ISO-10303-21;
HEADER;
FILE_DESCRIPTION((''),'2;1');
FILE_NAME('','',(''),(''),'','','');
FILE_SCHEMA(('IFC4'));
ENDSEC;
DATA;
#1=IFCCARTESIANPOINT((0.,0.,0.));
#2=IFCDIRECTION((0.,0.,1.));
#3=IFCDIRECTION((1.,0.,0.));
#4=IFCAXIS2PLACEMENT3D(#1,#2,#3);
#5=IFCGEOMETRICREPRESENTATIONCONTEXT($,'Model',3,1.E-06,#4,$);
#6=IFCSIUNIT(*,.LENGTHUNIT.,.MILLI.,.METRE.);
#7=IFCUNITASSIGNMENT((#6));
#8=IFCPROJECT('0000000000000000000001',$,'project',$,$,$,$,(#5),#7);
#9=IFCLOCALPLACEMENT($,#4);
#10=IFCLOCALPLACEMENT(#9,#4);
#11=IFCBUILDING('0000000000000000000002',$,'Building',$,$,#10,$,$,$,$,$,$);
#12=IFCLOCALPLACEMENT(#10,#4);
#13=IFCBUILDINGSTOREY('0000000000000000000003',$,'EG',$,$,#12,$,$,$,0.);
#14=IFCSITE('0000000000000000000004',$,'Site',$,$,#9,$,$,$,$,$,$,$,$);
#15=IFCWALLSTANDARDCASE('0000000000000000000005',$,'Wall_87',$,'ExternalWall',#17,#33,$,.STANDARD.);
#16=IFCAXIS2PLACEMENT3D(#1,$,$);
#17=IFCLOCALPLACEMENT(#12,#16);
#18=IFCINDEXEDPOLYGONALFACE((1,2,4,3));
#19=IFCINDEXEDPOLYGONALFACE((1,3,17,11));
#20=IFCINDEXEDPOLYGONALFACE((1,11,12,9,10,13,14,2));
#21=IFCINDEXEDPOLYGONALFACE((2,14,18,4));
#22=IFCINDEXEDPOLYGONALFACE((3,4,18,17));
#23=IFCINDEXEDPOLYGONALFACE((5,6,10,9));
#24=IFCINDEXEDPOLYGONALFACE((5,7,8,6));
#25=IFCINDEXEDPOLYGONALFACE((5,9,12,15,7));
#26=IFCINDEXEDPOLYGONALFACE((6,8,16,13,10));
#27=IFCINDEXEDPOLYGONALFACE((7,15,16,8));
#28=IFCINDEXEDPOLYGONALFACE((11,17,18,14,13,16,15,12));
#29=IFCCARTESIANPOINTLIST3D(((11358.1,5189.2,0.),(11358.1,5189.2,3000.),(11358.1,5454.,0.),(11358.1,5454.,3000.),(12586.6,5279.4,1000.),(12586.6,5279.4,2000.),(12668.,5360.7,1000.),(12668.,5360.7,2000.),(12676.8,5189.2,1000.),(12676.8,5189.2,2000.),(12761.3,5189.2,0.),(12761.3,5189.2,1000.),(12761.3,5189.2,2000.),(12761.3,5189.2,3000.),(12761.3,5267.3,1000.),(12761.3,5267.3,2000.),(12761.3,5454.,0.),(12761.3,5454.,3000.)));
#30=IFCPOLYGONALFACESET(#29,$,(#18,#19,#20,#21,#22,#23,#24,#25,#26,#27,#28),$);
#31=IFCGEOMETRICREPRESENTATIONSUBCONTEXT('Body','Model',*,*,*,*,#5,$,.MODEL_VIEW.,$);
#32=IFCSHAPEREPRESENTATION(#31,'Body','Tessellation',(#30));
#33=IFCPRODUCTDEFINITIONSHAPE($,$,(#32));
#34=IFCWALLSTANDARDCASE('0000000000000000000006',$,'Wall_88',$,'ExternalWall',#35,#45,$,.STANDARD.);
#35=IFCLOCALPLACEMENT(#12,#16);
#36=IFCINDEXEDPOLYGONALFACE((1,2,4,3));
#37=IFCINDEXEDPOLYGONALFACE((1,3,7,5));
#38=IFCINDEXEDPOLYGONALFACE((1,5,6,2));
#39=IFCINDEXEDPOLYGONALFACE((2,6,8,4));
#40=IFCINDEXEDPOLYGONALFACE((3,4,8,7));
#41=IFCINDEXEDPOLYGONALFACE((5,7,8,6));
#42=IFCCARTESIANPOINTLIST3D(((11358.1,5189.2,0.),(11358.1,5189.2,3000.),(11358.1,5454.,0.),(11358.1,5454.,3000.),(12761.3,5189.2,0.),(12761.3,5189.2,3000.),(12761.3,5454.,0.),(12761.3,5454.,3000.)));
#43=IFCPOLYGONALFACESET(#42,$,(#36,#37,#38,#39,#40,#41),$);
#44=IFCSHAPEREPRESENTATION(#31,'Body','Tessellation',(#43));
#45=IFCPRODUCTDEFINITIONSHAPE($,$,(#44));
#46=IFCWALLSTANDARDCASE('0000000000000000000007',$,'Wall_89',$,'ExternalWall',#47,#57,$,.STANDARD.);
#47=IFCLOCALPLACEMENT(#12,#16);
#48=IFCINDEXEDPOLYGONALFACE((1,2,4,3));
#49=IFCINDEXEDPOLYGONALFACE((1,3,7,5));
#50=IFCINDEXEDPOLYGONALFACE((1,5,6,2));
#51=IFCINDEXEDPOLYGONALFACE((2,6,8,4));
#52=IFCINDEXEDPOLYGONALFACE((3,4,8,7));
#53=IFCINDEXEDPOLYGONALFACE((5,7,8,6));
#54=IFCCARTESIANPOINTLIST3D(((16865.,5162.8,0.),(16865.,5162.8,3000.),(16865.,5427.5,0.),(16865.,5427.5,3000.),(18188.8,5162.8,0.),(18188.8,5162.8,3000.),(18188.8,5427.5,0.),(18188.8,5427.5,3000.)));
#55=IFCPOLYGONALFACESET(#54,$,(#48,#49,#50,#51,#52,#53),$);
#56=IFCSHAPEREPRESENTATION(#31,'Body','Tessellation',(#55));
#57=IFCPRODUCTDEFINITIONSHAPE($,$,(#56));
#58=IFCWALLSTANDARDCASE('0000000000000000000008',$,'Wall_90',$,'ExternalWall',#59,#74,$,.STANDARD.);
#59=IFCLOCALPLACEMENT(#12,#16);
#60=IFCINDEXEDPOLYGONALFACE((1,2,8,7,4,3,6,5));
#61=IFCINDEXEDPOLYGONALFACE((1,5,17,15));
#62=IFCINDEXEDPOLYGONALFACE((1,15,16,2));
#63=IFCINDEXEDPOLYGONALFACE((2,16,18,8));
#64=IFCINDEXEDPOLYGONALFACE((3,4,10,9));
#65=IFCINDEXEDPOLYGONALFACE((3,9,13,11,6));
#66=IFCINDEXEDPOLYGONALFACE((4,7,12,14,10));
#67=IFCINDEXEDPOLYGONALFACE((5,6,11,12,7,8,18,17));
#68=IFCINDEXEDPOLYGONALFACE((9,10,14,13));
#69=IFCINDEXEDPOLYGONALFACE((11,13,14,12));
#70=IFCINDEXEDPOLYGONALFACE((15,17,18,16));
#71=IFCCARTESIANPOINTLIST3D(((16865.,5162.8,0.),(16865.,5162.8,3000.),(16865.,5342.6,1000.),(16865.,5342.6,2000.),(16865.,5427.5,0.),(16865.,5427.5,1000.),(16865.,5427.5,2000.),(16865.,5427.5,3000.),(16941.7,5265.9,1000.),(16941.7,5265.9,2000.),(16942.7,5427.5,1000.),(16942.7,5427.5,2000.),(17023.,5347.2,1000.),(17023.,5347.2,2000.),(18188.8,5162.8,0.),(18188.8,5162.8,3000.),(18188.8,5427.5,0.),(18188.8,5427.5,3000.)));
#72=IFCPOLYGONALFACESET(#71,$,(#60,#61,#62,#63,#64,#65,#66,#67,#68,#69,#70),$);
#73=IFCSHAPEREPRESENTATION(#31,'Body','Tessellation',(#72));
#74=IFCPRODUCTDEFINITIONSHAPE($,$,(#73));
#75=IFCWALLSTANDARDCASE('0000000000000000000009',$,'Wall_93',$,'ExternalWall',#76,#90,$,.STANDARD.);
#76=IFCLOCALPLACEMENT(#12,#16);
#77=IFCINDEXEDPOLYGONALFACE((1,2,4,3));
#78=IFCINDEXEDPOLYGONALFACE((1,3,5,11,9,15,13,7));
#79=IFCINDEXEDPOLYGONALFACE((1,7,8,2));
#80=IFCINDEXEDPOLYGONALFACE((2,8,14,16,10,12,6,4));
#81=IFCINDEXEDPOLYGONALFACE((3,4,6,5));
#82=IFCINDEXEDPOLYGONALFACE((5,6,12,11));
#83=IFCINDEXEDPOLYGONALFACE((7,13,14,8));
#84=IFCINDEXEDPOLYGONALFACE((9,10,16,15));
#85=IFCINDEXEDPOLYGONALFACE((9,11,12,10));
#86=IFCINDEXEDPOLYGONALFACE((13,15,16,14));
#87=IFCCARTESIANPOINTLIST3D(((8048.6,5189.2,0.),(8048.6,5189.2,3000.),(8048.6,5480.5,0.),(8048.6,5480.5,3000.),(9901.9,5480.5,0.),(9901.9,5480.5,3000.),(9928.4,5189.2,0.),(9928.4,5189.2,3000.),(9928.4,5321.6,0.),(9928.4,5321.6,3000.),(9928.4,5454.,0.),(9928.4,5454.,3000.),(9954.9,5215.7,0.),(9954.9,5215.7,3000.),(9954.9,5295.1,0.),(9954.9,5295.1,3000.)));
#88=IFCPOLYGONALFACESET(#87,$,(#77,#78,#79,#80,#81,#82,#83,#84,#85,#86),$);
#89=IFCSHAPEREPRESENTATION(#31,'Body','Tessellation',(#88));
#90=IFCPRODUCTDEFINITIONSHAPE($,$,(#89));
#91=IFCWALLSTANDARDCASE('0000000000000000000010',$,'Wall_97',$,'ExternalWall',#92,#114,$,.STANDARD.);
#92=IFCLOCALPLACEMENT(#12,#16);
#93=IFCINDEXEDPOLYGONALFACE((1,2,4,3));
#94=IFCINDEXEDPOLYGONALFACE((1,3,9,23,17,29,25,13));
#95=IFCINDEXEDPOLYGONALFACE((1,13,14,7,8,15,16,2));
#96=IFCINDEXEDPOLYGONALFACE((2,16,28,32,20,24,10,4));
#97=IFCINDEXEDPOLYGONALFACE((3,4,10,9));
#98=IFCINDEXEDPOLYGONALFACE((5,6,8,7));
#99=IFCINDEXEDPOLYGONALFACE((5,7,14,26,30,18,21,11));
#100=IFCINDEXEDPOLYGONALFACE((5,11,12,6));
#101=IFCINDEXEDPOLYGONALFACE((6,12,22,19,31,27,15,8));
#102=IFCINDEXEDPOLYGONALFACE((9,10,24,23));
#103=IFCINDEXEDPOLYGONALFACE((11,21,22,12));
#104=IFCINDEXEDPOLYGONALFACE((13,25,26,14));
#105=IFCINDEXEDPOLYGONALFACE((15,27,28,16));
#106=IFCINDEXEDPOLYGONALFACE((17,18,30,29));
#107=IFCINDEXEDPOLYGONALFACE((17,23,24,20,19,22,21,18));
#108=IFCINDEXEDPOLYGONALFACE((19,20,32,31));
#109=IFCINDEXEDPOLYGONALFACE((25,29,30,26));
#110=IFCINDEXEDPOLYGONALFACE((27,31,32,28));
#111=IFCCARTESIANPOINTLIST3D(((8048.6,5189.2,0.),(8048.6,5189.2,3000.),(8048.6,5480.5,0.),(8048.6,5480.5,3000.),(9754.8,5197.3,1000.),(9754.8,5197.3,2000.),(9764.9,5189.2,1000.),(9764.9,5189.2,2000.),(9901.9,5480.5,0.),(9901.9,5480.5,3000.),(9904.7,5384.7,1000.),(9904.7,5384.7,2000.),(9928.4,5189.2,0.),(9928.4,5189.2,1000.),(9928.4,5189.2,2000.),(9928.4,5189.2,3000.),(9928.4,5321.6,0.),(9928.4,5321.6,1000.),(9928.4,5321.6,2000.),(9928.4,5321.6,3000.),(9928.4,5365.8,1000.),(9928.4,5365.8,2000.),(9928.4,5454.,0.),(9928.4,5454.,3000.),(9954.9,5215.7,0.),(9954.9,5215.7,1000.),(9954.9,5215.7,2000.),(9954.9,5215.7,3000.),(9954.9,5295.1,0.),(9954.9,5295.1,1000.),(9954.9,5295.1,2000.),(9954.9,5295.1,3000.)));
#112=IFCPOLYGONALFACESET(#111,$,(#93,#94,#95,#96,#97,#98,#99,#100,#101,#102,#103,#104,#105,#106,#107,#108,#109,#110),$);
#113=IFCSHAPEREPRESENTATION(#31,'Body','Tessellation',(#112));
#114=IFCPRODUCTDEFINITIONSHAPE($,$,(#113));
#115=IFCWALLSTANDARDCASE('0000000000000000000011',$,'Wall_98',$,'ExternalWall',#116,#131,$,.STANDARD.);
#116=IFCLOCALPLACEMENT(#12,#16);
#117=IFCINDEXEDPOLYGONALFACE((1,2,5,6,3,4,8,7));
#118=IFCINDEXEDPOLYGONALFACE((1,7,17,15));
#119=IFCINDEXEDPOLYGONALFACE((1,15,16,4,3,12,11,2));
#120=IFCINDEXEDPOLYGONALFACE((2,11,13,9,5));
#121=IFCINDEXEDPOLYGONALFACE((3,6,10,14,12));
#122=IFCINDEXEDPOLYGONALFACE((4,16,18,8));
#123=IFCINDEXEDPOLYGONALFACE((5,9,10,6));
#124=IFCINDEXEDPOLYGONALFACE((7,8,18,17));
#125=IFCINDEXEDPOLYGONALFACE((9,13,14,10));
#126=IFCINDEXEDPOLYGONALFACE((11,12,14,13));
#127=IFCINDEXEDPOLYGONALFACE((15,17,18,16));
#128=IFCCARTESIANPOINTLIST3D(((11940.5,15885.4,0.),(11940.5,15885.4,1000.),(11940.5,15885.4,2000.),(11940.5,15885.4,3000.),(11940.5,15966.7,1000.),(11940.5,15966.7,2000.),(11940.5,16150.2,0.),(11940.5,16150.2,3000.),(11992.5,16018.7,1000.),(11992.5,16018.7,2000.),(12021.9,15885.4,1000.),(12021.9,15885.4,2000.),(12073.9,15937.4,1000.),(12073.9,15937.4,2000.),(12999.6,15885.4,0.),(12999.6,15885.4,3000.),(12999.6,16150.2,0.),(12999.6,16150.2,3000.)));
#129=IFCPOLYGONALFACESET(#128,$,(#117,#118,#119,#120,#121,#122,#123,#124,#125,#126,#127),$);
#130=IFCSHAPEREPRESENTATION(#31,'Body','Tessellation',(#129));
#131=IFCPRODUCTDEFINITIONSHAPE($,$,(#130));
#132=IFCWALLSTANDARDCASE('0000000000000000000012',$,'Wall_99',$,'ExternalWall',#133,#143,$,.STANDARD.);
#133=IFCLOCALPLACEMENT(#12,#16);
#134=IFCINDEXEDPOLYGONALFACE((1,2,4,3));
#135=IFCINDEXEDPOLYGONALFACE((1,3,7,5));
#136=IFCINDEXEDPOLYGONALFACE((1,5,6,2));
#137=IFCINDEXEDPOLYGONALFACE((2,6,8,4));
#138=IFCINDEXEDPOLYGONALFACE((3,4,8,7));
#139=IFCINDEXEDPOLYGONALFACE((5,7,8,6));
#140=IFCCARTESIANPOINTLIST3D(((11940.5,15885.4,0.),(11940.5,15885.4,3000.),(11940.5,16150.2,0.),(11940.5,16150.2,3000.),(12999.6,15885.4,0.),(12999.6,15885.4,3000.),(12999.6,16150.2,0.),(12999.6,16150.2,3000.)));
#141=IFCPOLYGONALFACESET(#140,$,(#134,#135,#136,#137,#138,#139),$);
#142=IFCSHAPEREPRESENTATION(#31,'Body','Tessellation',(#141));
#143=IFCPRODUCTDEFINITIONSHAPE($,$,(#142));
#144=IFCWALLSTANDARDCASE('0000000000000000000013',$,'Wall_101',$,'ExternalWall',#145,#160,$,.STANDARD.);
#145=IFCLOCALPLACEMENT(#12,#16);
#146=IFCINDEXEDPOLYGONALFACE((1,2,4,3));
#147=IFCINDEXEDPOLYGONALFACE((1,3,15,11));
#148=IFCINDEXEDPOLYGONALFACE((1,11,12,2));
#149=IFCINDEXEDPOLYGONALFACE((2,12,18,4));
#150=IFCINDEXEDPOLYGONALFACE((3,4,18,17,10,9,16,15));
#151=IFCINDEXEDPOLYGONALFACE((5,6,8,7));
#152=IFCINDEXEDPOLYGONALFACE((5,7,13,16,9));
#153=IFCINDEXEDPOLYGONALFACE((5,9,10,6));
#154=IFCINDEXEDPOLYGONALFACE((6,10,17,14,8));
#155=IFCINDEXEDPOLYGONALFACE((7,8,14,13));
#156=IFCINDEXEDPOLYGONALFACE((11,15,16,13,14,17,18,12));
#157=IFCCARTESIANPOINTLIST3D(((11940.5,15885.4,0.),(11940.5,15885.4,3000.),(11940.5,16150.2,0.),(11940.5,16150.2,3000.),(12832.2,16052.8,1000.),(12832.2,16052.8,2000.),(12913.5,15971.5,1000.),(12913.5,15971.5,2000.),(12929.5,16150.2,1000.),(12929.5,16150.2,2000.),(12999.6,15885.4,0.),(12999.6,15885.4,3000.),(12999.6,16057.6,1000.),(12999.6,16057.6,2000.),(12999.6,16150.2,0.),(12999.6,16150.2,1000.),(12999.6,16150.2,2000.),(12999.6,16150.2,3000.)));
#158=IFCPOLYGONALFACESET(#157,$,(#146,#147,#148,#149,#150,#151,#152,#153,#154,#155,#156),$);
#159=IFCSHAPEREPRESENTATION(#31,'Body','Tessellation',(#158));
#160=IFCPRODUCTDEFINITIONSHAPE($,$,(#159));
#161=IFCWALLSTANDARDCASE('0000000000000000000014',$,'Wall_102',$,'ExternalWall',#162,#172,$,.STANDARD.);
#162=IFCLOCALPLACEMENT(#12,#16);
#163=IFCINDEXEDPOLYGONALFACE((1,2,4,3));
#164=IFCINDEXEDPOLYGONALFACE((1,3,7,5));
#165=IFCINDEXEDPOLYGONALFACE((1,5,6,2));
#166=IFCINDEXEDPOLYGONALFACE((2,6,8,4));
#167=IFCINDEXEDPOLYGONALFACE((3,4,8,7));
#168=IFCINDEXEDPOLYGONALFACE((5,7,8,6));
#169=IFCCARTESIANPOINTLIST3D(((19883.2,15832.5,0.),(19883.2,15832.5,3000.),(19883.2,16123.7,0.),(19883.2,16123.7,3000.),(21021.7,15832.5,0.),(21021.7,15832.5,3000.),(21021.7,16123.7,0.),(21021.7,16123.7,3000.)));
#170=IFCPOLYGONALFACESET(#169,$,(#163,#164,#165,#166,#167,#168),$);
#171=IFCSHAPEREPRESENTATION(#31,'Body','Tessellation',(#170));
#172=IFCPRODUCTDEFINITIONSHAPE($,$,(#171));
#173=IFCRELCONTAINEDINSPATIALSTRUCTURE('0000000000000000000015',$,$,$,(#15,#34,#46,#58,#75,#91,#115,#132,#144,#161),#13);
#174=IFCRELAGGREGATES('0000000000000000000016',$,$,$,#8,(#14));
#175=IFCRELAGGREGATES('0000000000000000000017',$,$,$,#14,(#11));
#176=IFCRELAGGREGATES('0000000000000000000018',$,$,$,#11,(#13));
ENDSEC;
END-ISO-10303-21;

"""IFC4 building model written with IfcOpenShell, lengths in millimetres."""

from ifc_helpers import new_model, si_unit, frame, origin_with_axes, place, context, subcontext, project, spatial, polyline, rectangle, outline, extrude, element, save


model = new_model("IFC4")

# Units and contexts
model_context = context("Model", 3, precision=1e-06, world=origin_with_axes())
body_context = subcontext(model_context, "Body", "Model", "MODEL_VIEW")
ifc_project = project(units=[si_unit("LENGTHUNIT", "METRE", prefix="MILLI")], contexts=[model_context])

# Site, building, storey
site_placement = place(None, origin_with_axes())
site = spatial("IfcSite", under=ifc_project, at=site_placement, Name="Site")
building_placement = place(site_placement, origin_with_axes())
building = spatial("IfcBuilding", under=site, at=building_placement, Name="Building")
storey_placement = place(building_placement, origin_with_axes())
storey = spatial("IfcBuildingStorey", under=building, at=storey_placement, Name="EG", Elevation=0.0)

# Wall, opening
wall_1_placement = place(storey_placement, origin_with_axes())
wall_1 = element("IfcWallStandardCase", 1, at=wall_1_placement, inside=storey, Name="Wall_87", ObjectType="ExternalWall", PredefinedType="STANDARD", context=body_context, shape_type="SweptSolid", body=[
    extrude(outline(polyline([(11358.1, 5189.2, 0.0), (11358.1, 5454.0, 0.0), (12761.3, 5454.0, 0.0), (12761.3, 5189.2, 0.0), (11358.1, 5189.2, 0.0)])), origin_with_axes(), (0.0, 0.0, 1.0), 3000.0),
])
opening_1_placement = place(wall_1_placement, origin_with_axes())
element("IfcOpeningElement", 2, at=opening_1_placement, inside=storey, cuts=wall_1, context=body_context, shape_type="SweptSolid", body=[
    extrude(rectangle(XDim=1123.3, YDim=115.0), frame((13024.4, 4922.9, 1000.0), z_axis=(0.0, 0.0, 1.0), x_axis=(0.707107, -0.707107, 0.0)), (0.0, 0.0, 1.0), 1000.0),
])

# Walls
wall_2_placement = place(storey_placement, origin_with_axes())
element("IfcWallStandardCase", 3, at=wall_2_placement, inside=storey, Name="Wall_88", ObjectType="ExternalWall", PredefinedType="STANDARD", context=body_context, shape_type="SweptSolid", body=[
    extrude(outline(polyline([(11358.1, 5189.2, 0.0), (11358.1, 5454.0, 0.0), (12761.3, 5454.0, 0.0), (12761.3, 5189.2, 0.0), (11358.1, 5189.2, 0.0)])), origin_with_axes(), (0.0, 0.0, 1.0), 3000.0),
])
wall_3_placement = place(storey_placement, origin_with_axes())
element("IfcWallStandardCase", 4, at=wall_3_placement, inside=storey, Name="Wall_89", ObjectType="ExternalWall", PredefinedType="STANDARD", context=body_context, shape_type="SweptSolid", body=[
    extrude(outline(polyline([(16865.0, 5162.8, 0.0), (16865.0, 5427.5, 0.0), (18188.8, 5427.5, 0.0), (18188.8, 5162.8, 0.0), (16865.0, 5162.8, 0.0)])), origin_with_axes(), (0.0, 0.0, 1.0), 3000.0),
])

# Wall, opening
wall_4_placement = place(storey_placement, origin_with_axes())
wall_4 = element("IfcWallStandardCase", 5, at=wall_4_placement, inside=storey, Name="Wall_90", ObjectType="ExternalWall", PredefinedType="STANDARD", context=body_context, shape_type="SweptSolid", body=[
    extrude(outline(polyline([(16865.0, 5162.8, 0.0), (16865.0, 5427.5, 0.0), (18188.8, 5427.5, 0.0), (18188.8, 5162.8, 0.0), (16865.0, 5162.8, 0.0)])), origin_with_axes(), (0.0, 0.0, 1.0), 3000.0),
])
opening_2_placement = place(wall_4_placement, origin_with_axes())
element("IfcOpeningElement", 6, at=opening_2_placement, inside=storey, cuts=wall_4, context=body_context, shape_type="SweptSolid", body=[
    extrude(rectangle(XDim=1142.0, YDim=115.0), frame((16578.6, 5710.3, 1000.0), z_axis=(0.0, 0.0, 1.0), x_axis=(-0.707107, 0.707107, 0.0)), (0.0, 0.0, 1.0), 1000.0),
])

# Wall
for number, where, z_axis, x_axis, name in (
    (7, (0.0, 0.0, 0.0), (0.0, 0.0, 1.0), (1.0, 0.0, 0.0), "Wall_93"),
):
    element("IfcWallStandardCase", number, at=place(storey_placement, frame(where, z_axis=z_axis, x_axis=x_axis)), inside=storey, Name=name, ObjectType="ExternalWall", PredefinedType="STANDARD", context=body_context, shape_type="SweptSolid", body=[
        extrude(outline(polyline([(8048.6, 5189.2, 0.0), (8048.6, 5480.5, 0.0), (9901.9, 5480.5, 0.0), (9928.4, 5454.0, 0.0), (9928.4, 5321.6, 0.0), (9954.9, 5295.1, 0.0), (9954.9, 5215.7, 0.0), (9928.4, 5189.2, 0.0), (8048.6, 5189.2, 0.0)])), origin_with_axes(), (0.0, 0.0, 1.0), 3000.0),
    ])

# Walls, openings
wall_5_placement = place(storey_placement, origin_with_axes())
wall_5 = element("IfcWallStandardCase", 8, at=wall_5_placement, inside=storey, Name="Wall_97", ObjectType="ExternalWall", PredefinedType="STANDARD", context=body_context, shape_type="SweptSolid", body=[
    extrude(outline(polyline([(8048.6, 5189.2, 0.0), (8048.6, 5480.5, 0.0), (9901.9, 5480.5, 0.0), (9928.4, 5454.0, 0.0), (9928.4, 5321.6, 0.0), (9954.9, 5295.1, 0.0), (9954.9, 5215.7, 0.0), (9928.4, 5189.2, 0.0), (8048.6, 5189.2, 0.0)])), origin_with_axes(), (0.0, 0.0, 1.0), 3000.0),
])
opening_3_placement = place(wall_5_placement, origin_with_axes())
element("IfcOpeningElement", 9, at=opening_3_placement, inside=storey, cuts=wall_5, context=body_context, shape_type="SweptSolid", body=[
    extrude(rectangle(XDim=1215.6, YDim=240.0), frame((10304.4, 4911.3, 1000.0), z_axis=(0.0, 0.0, 1.0), x_axis=(0.780869, -0.624695, 0.0)), (0.0, 0.0, 1.0), 1000.0),
])
wall_6_placement = place(storey_placement, origin_with_axes())
wall_6 = element("IfcWallStandardCase", 10, at=wall_6_placement, inside=storey, Name="Wall_98", ObjectType="ExternalWall", PredefinedType="STANDARD", context=body_context, shape_type="SweptSolid", body=[
    extrude(outline(polyline([(11940.5, 15885.4, 0.0), (11940.5, 16150.2, 0.0), (12999.6, 16150.2, 0.0), (12999.6, 15885.4, 0.0), (11940.5, 15885.4, 0.0)])), origin_with_axes(), (0.0, 0.0, 1.0), 3000.0),
])
opening_4_placement = place(wall_6_placement, origin_with_axes())
element("IfcOpeningElement", 11, at=opening_4_placement, inside=storey, cuts=wall_6, context=body_context, shape_type="SweptSolid", body=[
    extrude(rectangle(XDim=1160.7, YDim=115.0), frame((11622.8, 15567.7, 1000.0), z_axis=(0.0, 0.0, 1.0), x_axis=(-0.707107, -0.707107, 0.0)), (0.0, 0.0, 1.0), 1000.0),
])

# Wall
for number, where, z_axis, x_axis, name in (
    (12, (0.0, 0.0, 0.0), (0.0, 0.0, 1.0), (1.0, 0.0, 0.0), "Wall_99"),
):
    element("IfcWallStandardCase", number, at=place(storey_placement, frame(where, z_axis=z_axis, x_axis=x_axis)), inside=storey, Name=name, ObjectType="ExternalWall", PredefinedType="STANDARD", context=body_context, shape_type="SweptSolid", body=[
        extrude(outline(polyline([(11940.5, 15885.4, 0.0), (11940.5, 16150.2, 0.0), (12999.6, 16150.2, 0.0), (12999.6, 15885.4, 0.0), (11940.5, 15885.4, 0.0)])), origin_with_axes(), (0.0, 0.0, 1.0), 3000.0),
    ])

# Wall, opening
wall_7_placement = place(storey_placement, origin_with_axes())
wall_7 = element("IfcWallStandardCase", 13, at=wall_7_placement, inside=storey, Name="Wall_101", ObjectType="ExternalWall", PredefinedType="STANDARD", context=body_context, shape_type="SweptSolid", body=[
    extrude(outline(polyline([(11940.5, 15885.4, 0.0), (11940.5, 16150.2, 0.0), (12999.6, 16150.2, 0.0), (12999.6, 15885.4, 0.0), (11940.5, 15885.4, 0.0)])), origin_with_axes(), (0.0, 0.0, 1.0), 3000.0),
])
opening_5_placement = place(wall_7_placement, origin_with_axes())
element("IfcOpeningElement", 14, at=opening_5_placement, inside=storey, cuts=wall_7, context=body_context, shape_type="SweptSolid", body=[
    extrude(rectangle(XDim=1104.5, YDim=115.0), frame((13263.3, 16402.7, 1000.0), z_axis=(0.0, 0.0, 1.0), x_axis=(0.707107, 0.707107, 0.0)), (0.0, 0.0, 1.0), 1000.0),
])

# Wall
for number, where, z_axis, x_axis, name in (
    (15, (0.0, 0.0, 0.0), (0.0, 0.0, 1.0), (1.0, 0.0, 0.0), "Wall_102"),
):
    element("IfcWallStandardCase", number, at=place(storey_placement, frame(where, z_axis=z_axis, x_axis=x_axis)), inside=storey, Name=name, ObjectType="ExternalWall", PredefinedType="STANDARD", context=body_context, shape_type="SweptSolid", body=[
        extrude(outline(polyline([(19883.2, 15832.5, 0.0), (19883.2, 16123.7, 0.0), (21021.7, 16123.7, 0.0), (21021.7, 15832.5, 0.0), (19883.2, 15832.5, 0.0)])), origin_with_axes(), (0.0, 0.0, 1.0), 3000.0),
    ])

save(model, "model.ifc")
